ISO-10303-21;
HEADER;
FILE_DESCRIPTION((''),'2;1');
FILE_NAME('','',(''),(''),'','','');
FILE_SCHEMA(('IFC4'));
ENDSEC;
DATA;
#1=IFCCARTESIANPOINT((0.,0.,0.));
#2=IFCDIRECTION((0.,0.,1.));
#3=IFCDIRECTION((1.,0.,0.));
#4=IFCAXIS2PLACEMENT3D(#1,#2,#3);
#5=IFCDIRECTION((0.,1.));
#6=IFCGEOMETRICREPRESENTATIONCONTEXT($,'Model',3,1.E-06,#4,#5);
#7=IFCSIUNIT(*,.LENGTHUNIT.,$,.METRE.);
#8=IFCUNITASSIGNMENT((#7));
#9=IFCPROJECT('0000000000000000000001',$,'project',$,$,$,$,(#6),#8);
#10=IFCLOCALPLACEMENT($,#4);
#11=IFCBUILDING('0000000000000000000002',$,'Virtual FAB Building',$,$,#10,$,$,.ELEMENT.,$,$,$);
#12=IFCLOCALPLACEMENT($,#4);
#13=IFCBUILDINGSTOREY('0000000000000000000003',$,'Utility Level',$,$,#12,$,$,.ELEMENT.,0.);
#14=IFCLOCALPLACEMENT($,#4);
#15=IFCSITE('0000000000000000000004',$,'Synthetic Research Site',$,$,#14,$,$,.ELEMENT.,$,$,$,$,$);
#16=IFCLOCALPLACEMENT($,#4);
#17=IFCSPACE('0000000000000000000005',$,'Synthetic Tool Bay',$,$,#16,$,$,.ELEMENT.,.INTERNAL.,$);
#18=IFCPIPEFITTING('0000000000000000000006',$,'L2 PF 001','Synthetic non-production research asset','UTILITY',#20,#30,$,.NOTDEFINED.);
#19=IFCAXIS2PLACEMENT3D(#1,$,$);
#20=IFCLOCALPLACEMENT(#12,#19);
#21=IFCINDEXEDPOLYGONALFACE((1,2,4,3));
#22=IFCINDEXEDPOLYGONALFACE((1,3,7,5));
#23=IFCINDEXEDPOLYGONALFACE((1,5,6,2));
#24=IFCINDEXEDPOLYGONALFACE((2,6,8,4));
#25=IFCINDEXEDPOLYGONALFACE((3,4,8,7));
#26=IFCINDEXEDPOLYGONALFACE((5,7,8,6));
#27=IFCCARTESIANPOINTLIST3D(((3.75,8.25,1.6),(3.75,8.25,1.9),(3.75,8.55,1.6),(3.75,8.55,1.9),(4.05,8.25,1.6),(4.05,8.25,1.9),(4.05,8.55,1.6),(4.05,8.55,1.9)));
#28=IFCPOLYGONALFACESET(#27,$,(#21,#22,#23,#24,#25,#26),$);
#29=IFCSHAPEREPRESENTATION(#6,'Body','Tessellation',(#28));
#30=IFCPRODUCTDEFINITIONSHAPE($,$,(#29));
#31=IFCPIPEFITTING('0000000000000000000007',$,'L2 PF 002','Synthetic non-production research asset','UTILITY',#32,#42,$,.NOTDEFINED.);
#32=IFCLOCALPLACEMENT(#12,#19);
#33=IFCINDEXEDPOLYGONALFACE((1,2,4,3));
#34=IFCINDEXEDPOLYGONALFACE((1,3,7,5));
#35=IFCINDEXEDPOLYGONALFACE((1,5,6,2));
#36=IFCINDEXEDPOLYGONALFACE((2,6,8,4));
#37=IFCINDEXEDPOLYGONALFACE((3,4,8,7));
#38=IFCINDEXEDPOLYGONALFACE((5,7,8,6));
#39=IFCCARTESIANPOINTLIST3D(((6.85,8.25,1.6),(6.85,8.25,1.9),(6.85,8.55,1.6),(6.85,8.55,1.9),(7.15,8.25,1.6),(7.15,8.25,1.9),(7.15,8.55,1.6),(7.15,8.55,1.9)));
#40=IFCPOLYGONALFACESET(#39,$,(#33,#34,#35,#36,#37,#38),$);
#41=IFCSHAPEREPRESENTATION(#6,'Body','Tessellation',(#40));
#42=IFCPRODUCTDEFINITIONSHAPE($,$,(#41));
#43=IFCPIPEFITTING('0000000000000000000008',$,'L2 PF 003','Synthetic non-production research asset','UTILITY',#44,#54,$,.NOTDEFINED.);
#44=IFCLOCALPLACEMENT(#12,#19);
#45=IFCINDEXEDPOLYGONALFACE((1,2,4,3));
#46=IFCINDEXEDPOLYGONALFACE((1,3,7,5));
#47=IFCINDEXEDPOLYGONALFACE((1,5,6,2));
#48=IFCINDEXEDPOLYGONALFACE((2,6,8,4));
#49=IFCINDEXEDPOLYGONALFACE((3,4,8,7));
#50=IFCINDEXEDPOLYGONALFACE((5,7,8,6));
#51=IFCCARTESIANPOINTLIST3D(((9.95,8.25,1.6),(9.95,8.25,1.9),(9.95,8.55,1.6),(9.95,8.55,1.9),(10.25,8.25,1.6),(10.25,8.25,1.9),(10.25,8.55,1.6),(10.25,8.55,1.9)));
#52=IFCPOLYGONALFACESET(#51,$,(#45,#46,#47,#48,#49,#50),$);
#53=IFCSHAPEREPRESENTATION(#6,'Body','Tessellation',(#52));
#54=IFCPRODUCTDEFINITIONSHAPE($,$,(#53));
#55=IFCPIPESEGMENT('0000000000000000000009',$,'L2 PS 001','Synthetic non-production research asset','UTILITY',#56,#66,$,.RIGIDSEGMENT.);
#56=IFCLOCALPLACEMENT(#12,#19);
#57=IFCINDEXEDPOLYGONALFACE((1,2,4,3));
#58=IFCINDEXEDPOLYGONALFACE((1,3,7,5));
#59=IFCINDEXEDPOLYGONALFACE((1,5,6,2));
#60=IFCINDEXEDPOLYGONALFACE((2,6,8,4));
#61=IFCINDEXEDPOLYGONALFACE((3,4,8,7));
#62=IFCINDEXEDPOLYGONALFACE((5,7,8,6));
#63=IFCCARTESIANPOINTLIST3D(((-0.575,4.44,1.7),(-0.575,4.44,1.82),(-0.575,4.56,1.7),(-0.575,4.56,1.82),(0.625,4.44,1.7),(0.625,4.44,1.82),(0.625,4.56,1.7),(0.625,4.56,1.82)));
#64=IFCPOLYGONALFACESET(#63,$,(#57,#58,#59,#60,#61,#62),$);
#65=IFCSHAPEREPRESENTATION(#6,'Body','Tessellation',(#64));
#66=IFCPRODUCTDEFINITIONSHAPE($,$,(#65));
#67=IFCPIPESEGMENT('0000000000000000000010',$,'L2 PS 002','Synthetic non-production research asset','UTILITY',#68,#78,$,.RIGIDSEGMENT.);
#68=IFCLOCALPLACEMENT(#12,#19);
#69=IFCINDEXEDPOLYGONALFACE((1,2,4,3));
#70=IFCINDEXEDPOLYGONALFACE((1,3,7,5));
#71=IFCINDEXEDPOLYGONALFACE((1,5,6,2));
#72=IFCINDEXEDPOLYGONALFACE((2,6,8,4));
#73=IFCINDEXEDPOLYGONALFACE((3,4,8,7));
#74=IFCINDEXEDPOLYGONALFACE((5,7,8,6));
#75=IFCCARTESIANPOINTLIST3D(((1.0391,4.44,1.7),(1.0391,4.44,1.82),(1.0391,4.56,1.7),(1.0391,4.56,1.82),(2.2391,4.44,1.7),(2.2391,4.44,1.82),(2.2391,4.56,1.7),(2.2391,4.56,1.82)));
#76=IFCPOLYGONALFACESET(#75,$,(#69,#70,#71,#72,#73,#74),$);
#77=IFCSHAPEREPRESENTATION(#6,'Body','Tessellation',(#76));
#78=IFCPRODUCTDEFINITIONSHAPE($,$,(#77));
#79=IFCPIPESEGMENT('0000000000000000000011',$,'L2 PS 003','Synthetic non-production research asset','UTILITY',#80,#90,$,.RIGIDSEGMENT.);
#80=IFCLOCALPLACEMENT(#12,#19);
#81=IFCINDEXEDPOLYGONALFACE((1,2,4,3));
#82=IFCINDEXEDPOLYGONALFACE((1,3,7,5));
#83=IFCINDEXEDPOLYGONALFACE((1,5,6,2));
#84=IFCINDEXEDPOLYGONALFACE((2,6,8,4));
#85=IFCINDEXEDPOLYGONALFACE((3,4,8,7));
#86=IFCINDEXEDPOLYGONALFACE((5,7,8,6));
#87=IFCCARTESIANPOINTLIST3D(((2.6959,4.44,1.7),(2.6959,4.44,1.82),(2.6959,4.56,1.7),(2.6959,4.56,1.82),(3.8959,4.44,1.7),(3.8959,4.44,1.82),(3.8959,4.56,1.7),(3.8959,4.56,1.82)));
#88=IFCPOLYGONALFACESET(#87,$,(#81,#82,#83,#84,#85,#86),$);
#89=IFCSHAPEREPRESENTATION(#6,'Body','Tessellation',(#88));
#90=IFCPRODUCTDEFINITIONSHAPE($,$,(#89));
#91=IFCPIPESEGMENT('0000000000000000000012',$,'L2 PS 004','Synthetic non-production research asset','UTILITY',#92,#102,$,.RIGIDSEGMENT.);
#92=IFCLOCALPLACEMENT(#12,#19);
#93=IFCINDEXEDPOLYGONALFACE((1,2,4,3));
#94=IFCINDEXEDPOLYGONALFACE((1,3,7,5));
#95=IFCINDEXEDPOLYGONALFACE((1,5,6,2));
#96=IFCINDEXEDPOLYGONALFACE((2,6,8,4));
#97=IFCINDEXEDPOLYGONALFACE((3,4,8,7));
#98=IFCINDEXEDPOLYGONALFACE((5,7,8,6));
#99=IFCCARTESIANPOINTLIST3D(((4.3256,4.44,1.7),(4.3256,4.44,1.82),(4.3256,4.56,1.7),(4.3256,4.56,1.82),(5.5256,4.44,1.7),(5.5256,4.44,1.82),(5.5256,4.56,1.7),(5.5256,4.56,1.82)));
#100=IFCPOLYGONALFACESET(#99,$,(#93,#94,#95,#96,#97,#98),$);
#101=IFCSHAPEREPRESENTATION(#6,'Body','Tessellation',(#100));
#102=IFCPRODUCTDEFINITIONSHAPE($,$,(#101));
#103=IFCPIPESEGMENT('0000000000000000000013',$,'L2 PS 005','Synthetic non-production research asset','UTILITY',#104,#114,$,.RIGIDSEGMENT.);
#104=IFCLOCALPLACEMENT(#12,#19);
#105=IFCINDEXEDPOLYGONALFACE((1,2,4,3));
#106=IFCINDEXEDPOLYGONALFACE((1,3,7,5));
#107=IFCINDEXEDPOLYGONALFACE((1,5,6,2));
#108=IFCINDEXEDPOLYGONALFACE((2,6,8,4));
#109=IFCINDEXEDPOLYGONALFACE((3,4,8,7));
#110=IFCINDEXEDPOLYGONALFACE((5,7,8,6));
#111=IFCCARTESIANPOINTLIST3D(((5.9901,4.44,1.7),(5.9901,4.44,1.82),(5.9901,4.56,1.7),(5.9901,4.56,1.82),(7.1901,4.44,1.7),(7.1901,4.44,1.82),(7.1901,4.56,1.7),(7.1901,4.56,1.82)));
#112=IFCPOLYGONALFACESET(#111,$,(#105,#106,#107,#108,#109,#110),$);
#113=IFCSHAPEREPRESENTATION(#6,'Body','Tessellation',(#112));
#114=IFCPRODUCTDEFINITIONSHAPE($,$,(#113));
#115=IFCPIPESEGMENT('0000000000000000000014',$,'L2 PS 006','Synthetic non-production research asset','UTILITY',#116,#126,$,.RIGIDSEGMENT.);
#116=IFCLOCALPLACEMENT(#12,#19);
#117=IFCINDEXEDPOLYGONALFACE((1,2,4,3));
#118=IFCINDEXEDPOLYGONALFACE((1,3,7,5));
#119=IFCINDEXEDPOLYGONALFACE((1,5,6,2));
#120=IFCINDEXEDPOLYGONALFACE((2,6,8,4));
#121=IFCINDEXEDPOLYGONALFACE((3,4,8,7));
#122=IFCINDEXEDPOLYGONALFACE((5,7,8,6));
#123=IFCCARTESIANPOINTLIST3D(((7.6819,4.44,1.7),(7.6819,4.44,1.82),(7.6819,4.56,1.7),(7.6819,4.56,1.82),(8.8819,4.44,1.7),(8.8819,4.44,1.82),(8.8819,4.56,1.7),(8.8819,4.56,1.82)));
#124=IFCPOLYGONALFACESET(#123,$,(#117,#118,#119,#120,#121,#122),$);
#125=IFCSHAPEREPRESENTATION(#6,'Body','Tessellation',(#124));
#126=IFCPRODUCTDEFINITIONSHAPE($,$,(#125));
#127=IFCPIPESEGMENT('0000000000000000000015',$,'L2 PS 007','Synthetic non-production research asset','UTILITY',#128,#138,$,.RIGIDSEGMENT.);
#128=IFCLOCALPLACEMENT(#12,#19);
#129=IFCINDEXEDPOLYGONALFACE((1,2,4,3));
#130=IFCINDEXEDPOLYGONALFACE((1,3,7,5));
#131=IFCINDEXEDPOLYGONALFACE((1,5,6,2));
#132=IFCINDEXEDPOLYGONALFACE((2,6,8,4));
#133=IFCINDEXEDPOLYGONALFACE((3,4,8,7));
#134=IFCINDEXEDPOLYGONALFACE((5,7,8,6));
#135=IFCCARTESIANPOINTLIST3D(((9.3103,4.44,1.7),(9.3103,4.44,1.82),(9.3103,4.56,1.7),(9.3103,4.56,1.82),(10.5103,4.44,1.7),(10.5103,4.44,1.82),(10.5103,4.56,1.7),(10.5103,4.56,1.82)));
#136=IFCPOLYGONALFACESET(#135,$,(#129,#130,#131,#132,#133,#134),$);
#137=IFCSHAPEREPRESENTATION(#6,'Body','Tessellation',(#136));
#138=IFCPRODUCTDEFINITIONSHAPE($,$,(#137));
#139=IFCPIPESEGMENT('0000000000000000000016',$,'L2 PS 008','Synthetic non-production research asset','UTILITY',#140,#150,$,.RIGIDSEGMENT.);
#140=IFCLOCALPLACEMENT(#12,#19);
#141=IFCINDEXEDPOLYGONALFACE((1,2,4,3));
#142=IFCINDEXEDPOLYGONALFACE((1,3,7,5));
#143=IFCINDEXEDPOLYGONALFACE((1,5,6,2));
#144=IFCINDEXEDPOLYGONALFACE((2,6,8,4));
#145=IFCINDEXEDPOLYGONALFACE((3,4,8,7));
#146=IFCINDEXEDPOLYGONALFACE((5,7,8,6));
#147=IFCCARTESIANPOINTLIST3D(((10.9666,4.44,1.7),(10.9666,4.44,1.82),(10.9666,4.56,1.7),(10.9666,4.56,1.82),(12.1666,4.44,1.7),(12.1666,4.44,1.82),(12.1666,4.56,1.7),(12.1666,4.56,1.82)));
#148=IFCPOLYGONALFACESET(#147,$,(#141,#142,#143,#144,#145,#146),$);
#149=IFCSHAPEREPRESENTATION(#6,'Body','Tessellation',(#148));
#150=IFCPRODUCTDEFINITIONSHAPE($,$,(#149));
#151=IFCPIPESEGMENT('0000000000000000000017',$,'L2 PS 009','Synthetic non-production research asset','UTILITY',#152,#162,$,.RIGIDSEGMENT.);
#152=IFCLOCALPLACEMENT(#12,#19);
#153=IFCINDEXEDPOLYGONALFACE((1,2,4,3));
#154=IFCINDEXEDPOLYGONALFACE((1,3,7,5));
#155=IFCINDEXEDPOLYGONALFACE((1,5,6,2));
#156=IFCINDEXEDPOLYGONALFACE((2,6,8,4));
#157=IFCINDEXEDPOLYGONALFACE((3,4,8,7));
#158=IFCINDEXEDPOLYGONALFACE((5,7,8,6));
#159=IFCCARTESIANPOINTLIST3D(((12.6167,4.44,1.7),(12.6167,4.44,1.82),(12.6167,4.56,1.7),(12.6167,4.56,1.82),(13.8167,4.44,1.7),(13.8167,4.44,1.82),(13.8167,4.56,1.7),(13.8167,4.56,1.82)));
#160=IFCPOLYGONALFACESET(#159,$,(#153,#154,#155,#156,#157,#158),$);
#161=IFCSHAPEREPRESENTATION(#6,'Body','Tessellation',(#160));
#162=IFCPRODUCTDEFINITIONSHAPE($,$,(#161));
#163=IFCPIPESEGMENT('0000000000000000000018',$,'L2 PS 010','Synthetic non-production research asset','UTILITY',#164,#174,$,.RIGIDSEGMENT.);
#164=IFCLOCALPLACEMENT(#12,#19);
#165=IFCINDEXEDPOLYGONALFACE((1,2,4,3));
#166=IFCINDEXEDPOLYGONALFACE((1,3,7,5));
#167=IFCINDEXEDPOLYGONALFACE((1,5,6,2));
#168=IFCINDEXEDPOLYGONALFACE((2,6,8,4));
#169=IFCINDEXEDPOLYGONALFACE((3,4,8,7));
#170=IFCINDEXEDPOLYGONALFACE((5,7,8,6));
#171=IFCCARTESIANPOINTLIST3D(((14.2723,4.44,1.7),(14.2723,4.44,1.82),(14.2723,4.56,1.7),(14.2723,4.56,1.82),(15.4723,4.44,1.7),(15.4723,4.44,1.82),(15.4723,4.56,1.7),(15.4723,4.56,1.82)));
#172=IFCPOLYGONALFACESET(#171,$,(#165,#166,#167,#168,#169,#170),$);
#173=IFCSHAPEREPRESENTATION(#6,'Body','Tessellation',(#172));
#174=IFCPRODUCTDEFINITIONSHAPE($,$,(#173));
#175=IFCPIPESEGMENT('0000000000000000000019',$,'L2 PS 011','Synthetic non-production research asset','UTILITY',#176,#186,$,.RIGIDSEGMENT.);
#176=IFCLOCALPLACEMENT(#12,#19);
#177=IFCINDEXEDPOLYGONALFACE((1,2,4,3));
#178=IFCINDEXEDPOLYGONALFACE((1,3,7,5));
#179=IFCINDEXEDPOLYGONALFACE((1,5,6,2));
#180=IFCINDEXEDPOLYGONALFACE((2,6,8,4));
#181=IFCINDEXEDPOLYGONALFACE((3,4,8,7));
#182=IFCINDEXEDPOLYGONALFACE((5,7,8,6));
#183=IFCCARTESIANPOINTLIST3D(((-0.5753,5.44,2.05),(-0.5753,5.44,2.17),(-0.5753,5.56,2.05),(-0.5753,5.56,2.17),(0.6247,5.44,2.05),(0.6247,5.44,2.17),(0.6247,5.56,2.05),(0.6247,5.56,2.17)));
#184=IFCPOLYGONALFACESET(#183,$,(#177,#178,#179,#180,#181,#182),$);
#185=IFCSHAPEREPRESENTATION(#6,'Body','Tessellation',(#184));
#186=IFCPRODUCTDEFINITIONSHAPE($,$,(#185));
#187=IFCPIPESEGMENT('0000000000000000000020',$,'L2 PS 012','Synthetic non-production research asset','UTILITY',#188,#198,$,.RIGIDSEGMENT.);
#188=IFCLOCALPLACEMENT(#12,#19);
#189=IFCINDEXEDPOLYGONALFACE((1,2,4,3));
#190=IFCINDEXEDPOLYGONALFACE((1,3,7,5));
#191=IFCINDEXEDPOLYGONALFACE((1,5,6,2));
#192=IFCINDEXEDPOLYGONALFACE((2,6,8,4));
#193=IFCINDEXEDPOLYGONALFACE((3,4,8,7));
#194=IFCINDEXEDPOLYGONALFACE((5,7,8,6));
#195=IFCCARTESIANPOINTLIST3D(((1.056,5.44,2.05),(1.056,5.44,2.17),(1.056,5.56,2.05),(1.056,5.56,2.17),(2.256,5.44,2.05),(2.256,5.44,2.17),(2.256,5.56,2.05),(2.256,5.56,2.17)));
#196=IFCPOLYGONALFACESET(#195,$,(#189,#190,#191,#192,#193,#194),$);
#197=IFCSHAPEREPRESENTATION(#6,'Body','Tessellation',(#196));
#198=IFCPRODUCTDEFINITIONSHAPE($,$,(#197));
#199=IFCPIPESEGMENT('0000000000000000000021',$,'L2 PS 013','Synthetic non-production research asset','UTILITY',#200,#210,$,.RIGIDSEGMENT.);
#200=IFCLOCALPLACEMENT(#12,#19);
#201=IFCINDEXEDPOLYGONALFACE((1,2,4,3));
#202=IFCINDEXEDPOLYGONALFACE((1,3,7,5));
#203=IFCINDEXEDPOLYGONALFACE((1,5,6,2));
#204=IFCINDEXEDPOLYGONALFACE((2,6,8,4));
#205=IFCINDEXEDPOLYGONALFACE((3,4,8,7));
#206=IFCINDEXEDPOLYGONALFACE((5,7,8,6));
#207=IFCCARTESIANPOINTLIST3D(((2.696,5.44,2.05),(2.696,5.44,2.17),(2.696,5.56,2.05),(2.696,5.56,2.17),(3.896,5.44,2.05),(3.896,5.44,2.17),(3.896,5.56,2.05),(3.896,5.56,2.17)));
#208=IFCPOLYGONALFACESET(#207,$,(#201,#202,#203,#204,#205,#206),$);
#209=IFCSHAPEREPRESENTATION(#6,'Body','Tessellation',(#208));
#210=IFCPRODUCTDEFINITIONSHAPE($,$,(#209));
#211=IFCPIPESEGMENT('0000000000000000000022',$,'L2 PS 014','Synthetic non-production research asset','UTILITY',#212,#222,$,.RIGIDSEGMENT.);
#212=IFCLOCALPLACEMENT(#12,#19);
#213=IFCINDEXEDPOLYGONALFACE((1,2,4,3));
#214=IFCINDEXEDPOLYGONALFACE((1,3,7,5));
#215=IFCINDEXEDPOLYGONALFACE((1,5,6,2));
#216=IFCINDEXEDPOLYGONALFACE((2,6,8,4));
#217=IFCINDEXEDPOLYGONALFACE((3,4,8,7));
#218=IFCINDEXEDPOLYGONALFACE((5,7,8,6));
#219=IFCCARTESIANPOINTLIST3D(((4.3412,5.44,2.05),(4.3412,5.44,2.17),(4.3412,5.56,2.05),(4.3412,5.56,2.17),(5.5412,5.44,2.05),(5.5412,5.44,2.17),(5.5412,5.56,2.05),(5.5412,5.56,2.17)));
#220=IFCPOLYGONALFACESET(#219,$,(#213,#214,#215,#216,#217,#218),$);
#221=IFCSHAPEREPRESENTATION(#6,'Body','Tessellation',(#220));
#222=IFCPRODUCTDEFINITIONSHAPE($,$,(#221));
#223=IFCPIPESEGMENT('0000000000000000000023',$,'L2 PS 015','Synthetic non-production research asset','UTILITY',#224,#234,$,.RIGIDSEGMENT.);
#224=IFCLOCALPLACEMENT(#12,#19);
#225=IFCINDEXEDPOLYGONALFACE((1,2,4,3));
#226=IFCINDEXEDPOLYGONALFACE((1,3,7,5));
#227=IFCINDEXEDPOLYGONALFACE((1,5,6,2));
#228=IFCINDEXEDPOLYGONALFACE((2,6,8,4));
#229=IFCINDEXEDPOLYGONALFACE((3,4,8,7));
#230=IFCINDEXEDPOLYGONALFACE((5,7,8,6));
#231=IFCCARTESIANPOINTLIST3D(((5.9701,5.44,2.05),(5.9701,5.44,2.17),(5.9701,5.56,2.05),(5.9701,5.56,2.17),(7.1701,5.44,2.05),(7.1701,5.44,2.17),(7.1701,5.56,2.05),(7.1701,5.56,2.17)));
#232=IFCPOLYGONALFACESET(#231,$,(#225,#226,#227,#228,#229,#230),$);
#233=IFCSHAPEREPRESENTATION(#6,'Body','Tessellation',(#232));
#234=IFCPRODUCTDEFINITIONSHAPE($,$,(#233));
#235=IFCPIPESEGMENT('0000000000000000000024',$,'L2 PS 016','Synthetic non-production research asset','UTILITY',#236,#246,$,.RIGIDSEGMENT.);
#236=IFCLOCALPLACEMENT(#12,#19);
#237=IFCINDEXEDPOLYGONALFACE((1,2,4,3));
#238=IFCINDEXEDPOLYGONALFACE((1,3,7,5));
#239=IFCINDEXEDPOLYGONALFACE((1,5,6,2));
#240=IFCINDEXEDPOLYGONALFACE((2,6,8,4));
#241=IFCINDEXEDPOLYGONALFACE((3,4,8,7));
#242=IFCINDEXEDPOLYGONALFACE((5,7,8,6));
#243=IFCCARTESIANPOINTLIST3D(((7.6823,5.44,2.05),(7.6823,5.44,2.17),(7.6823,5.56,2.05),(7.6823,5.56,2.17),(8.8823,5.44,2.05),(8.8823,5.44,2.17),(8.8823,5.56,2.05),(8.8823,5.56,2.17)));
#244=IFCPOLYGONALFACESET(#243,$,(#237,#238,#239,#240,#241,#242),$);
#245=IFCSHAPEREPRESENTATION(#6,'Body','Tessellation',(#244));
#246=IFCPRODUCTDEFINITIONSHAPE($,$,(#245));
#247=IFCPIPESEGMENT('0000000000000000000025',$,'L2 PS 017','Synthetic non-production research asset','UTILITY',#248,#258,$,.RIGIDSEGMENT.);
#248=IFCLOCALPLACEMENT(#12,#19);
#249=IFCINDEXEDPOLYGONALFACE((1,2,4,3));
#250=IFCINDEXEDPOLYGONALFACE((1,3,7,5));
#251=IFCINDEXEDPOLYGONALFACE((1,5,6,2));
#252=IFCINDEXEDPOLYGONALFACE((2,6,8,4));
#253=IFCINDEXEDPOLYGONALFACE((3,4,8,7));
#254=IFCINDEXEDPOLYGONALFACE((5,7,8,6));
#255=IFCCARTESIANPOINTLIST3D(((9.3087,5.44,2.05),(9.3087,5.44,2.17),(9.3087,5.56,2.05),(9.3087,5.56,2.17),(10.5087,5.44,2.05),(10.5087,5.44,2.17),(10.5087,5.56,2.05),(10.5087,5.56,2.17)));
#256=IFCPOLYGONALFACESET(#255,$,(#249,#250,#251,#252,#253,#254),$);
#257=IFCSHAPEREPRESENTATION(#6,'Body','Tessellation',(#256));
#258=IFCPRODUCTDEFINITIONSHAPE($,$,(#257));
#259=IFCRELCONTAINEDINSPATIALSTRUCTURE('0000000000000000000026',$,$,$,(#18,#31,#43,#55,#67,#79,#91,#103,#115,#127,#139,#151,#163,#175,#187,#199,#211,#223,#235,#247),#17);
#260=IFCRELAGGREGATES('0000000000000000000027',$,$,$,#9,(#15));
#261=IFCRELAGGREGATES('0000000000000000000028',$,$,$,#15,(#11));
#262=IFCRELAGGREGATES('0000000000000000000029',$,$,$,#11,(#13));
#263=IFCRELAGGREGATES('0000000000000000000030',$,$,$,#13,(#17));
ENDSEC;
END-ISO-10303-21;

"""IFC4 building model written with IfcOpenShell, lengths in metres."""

from ifc_helpers import new_model, si_unit, direction, frame, origin_with_axes, origin_2d_with_axis, place, context, project, spatial, rectangle, extrude, element, save


model = new_model("IFC4")

# Units and contexts
model_context = context("Model", 3, precision=1e-06, world=origin_with_axes(), true_north=direction((0.0, 1.0)))
ifc_project = project(units=[si_unit("LENGTHUNIT", "METRE")], contexts=[model_context])

# Site, building, storey, space
site_placement = place(None, origin_with_axes())
site = spatial("IfcSite", under=ifc_project, at=site_placement, Name="Synthetic Research Site", CompositionType="ELEMENT")
building_placement = place(None, origin_with_axes())
building = spatial("IfcBuilding", under=site, at=building_placement, Name="Virtual FAB Building", CompositionType="ELEMENT")
storey_placement = place(None, origin_with_axes())
storey = spatial("IfcBuildingStorey", under=building, at=storey_placement, Name="Utility Level", CompositionType="ELEMENT", Elevation=0.0)
space_placement = place(None, origin_with_axes())
space = spatial("IfcSpace", under=storey, at=space_placement, Name="Synthetic Tool Bay", CompositionType="ELEMENT", PredefinedType="INTERNAL")

# Pipe fittings
for number, where, z_axis, x_axis, name in (
    (1, (3.9, 8.4, 1.6), (0.0, 0.0, 1.0), (1.0, 0.0, 0.0), "L2 PF 001"),
    (2, (7.0, 8.4, 1.6), (0.0, 0.0, 1.0), (1.0, 0.0, 0.0), "L2 PF 002"),
    (3, (10.1, 8.4, 1.6), (0.0, 0.0, 1.0), (1.0, 0.0, 0.0), "L2 PF 003"),
):
    element("IfcPipeFitting", number, at=place(None, frame(where, z_axis=z_axis, x_axis=x_axis)), inside=space, Name=name, Description="Synthetic non-production research asset", ObjectType="UTILITY", PredefinedType="NOTDEFINED", context=model_context, shape_type="SweptSolid", body=[
        extrude(rectangle(XDim=0.3, YDim=0.3, at=origin_2d_with_axis()), origin_with_axes(), (0.0, 0.0, 1.0), 0.3),
    ])

# Pipe segments
for number, where, z_axis, x_axis, name in (
    (4, (0.025, 4.5, 1.7), (0.0, 0.0, 1.0), (1.0, 0.0, 0.0), "L2 PS 001"),
    (5, (1.6391, 4.5, 1.7), (0.0, 0.0, 1.0), (1.0, 0.0, 0.0), "L2 PS 002"),
    (6, (3.2959, 4.5, 1.7), (0.0, 0.0, 1.0), (1.0, 0.0, 0.0), "L2 PS 003"),
    (7, (4.9256, 4.5, 1.7), (0.0, 0.0, 1.0), (1.0, 0.0, 0.0), "L2 PS 004"),
    (8, (6.5901, 4.5, 1.7), (0.0, 0.0, 1.0), (1.0, 0.0, 0.0), "L2 PS 005"),
    (9, (8.2819, 4.5, 1.7), (0.0, 0.0, 1.0), (1.0, 0.0, 0.0), "L2 PS 006"),
    (10, (9.9103, 4.5, 1.7), (0.0, 0.0, 1.0), (1.0, 0.0, 0.0), "L2 PS 007"),
    (11, (11.5666, 4.5, 1.7), (0.0, 0.0, 1.0), (1.0, 0.0, 0.0), "L2 PS 008"),
    (12, (13.2167, 4.5, 1.7), (0.0, 0.0, 1.0), (1.0, 0.0, 0.0), "L2 PS 009"),
    (13, (14.8723, 4.5, 1.7), (0.0, 0.0, 1.0), (1.0, 0.0, 0.0), "L2 PS 010"),
    (14, (0.0247, 5.5, 2.05), (0.0, 0.0, 1.0), (1.0, 0.0, 0.0), "L2 PS 011"),
    (15, (1.656, 5.5, 2.05), (0.0, 0.0, 1.0), (1.0, 0.0, 0.0), "L2 PS 012"),
    (16, (3.296, 5.5, 2.05), (0.0, 0.0, 1.0), (1.0, 0.0, 0.0), "L2 PS 013"),
    (17, (4.9412, 5.5, 2.05), (0.0, 0.0, 1.0), (1.0, 0.0, 0.0), "L2 PS 014"),
    (18, (6.5701, 5.5, 2.05), (0.0, 0.0, 1.0), (1.0, 0.0, 0.0), "L2 PS 015"),
    (19, (8.2823, 5.5, 2.05), (0.0, 0.0, 1.0), (1.0, 0.0, 0.0), "L2 PS 016"),
    (20, (9.9087, 5.5, 2.05), (0.0, 0.0, 1.0), (1.0, 0.0, 0.0), "L2 PS 017"),
):
    element("IfcPipeSegment", number, at=place(None, frame(where, z_axis=z_axis, x_axis=x_axis)), inside=space, Name=name, Description="Synthetic non-production research asset", ObjectType="UTILITY", PredefinedType="RIGIDSEGMENT", context=model_context, shape_type="SweptSolid", body=[
        extrude(rectangle(XDim=1.2, YDim=0.12, at=origin_2d_with_axis()), origin_with_axes(), (0.0, 0.0, 1.0), 0.12),
    ])

save(model, "model.ifc")
